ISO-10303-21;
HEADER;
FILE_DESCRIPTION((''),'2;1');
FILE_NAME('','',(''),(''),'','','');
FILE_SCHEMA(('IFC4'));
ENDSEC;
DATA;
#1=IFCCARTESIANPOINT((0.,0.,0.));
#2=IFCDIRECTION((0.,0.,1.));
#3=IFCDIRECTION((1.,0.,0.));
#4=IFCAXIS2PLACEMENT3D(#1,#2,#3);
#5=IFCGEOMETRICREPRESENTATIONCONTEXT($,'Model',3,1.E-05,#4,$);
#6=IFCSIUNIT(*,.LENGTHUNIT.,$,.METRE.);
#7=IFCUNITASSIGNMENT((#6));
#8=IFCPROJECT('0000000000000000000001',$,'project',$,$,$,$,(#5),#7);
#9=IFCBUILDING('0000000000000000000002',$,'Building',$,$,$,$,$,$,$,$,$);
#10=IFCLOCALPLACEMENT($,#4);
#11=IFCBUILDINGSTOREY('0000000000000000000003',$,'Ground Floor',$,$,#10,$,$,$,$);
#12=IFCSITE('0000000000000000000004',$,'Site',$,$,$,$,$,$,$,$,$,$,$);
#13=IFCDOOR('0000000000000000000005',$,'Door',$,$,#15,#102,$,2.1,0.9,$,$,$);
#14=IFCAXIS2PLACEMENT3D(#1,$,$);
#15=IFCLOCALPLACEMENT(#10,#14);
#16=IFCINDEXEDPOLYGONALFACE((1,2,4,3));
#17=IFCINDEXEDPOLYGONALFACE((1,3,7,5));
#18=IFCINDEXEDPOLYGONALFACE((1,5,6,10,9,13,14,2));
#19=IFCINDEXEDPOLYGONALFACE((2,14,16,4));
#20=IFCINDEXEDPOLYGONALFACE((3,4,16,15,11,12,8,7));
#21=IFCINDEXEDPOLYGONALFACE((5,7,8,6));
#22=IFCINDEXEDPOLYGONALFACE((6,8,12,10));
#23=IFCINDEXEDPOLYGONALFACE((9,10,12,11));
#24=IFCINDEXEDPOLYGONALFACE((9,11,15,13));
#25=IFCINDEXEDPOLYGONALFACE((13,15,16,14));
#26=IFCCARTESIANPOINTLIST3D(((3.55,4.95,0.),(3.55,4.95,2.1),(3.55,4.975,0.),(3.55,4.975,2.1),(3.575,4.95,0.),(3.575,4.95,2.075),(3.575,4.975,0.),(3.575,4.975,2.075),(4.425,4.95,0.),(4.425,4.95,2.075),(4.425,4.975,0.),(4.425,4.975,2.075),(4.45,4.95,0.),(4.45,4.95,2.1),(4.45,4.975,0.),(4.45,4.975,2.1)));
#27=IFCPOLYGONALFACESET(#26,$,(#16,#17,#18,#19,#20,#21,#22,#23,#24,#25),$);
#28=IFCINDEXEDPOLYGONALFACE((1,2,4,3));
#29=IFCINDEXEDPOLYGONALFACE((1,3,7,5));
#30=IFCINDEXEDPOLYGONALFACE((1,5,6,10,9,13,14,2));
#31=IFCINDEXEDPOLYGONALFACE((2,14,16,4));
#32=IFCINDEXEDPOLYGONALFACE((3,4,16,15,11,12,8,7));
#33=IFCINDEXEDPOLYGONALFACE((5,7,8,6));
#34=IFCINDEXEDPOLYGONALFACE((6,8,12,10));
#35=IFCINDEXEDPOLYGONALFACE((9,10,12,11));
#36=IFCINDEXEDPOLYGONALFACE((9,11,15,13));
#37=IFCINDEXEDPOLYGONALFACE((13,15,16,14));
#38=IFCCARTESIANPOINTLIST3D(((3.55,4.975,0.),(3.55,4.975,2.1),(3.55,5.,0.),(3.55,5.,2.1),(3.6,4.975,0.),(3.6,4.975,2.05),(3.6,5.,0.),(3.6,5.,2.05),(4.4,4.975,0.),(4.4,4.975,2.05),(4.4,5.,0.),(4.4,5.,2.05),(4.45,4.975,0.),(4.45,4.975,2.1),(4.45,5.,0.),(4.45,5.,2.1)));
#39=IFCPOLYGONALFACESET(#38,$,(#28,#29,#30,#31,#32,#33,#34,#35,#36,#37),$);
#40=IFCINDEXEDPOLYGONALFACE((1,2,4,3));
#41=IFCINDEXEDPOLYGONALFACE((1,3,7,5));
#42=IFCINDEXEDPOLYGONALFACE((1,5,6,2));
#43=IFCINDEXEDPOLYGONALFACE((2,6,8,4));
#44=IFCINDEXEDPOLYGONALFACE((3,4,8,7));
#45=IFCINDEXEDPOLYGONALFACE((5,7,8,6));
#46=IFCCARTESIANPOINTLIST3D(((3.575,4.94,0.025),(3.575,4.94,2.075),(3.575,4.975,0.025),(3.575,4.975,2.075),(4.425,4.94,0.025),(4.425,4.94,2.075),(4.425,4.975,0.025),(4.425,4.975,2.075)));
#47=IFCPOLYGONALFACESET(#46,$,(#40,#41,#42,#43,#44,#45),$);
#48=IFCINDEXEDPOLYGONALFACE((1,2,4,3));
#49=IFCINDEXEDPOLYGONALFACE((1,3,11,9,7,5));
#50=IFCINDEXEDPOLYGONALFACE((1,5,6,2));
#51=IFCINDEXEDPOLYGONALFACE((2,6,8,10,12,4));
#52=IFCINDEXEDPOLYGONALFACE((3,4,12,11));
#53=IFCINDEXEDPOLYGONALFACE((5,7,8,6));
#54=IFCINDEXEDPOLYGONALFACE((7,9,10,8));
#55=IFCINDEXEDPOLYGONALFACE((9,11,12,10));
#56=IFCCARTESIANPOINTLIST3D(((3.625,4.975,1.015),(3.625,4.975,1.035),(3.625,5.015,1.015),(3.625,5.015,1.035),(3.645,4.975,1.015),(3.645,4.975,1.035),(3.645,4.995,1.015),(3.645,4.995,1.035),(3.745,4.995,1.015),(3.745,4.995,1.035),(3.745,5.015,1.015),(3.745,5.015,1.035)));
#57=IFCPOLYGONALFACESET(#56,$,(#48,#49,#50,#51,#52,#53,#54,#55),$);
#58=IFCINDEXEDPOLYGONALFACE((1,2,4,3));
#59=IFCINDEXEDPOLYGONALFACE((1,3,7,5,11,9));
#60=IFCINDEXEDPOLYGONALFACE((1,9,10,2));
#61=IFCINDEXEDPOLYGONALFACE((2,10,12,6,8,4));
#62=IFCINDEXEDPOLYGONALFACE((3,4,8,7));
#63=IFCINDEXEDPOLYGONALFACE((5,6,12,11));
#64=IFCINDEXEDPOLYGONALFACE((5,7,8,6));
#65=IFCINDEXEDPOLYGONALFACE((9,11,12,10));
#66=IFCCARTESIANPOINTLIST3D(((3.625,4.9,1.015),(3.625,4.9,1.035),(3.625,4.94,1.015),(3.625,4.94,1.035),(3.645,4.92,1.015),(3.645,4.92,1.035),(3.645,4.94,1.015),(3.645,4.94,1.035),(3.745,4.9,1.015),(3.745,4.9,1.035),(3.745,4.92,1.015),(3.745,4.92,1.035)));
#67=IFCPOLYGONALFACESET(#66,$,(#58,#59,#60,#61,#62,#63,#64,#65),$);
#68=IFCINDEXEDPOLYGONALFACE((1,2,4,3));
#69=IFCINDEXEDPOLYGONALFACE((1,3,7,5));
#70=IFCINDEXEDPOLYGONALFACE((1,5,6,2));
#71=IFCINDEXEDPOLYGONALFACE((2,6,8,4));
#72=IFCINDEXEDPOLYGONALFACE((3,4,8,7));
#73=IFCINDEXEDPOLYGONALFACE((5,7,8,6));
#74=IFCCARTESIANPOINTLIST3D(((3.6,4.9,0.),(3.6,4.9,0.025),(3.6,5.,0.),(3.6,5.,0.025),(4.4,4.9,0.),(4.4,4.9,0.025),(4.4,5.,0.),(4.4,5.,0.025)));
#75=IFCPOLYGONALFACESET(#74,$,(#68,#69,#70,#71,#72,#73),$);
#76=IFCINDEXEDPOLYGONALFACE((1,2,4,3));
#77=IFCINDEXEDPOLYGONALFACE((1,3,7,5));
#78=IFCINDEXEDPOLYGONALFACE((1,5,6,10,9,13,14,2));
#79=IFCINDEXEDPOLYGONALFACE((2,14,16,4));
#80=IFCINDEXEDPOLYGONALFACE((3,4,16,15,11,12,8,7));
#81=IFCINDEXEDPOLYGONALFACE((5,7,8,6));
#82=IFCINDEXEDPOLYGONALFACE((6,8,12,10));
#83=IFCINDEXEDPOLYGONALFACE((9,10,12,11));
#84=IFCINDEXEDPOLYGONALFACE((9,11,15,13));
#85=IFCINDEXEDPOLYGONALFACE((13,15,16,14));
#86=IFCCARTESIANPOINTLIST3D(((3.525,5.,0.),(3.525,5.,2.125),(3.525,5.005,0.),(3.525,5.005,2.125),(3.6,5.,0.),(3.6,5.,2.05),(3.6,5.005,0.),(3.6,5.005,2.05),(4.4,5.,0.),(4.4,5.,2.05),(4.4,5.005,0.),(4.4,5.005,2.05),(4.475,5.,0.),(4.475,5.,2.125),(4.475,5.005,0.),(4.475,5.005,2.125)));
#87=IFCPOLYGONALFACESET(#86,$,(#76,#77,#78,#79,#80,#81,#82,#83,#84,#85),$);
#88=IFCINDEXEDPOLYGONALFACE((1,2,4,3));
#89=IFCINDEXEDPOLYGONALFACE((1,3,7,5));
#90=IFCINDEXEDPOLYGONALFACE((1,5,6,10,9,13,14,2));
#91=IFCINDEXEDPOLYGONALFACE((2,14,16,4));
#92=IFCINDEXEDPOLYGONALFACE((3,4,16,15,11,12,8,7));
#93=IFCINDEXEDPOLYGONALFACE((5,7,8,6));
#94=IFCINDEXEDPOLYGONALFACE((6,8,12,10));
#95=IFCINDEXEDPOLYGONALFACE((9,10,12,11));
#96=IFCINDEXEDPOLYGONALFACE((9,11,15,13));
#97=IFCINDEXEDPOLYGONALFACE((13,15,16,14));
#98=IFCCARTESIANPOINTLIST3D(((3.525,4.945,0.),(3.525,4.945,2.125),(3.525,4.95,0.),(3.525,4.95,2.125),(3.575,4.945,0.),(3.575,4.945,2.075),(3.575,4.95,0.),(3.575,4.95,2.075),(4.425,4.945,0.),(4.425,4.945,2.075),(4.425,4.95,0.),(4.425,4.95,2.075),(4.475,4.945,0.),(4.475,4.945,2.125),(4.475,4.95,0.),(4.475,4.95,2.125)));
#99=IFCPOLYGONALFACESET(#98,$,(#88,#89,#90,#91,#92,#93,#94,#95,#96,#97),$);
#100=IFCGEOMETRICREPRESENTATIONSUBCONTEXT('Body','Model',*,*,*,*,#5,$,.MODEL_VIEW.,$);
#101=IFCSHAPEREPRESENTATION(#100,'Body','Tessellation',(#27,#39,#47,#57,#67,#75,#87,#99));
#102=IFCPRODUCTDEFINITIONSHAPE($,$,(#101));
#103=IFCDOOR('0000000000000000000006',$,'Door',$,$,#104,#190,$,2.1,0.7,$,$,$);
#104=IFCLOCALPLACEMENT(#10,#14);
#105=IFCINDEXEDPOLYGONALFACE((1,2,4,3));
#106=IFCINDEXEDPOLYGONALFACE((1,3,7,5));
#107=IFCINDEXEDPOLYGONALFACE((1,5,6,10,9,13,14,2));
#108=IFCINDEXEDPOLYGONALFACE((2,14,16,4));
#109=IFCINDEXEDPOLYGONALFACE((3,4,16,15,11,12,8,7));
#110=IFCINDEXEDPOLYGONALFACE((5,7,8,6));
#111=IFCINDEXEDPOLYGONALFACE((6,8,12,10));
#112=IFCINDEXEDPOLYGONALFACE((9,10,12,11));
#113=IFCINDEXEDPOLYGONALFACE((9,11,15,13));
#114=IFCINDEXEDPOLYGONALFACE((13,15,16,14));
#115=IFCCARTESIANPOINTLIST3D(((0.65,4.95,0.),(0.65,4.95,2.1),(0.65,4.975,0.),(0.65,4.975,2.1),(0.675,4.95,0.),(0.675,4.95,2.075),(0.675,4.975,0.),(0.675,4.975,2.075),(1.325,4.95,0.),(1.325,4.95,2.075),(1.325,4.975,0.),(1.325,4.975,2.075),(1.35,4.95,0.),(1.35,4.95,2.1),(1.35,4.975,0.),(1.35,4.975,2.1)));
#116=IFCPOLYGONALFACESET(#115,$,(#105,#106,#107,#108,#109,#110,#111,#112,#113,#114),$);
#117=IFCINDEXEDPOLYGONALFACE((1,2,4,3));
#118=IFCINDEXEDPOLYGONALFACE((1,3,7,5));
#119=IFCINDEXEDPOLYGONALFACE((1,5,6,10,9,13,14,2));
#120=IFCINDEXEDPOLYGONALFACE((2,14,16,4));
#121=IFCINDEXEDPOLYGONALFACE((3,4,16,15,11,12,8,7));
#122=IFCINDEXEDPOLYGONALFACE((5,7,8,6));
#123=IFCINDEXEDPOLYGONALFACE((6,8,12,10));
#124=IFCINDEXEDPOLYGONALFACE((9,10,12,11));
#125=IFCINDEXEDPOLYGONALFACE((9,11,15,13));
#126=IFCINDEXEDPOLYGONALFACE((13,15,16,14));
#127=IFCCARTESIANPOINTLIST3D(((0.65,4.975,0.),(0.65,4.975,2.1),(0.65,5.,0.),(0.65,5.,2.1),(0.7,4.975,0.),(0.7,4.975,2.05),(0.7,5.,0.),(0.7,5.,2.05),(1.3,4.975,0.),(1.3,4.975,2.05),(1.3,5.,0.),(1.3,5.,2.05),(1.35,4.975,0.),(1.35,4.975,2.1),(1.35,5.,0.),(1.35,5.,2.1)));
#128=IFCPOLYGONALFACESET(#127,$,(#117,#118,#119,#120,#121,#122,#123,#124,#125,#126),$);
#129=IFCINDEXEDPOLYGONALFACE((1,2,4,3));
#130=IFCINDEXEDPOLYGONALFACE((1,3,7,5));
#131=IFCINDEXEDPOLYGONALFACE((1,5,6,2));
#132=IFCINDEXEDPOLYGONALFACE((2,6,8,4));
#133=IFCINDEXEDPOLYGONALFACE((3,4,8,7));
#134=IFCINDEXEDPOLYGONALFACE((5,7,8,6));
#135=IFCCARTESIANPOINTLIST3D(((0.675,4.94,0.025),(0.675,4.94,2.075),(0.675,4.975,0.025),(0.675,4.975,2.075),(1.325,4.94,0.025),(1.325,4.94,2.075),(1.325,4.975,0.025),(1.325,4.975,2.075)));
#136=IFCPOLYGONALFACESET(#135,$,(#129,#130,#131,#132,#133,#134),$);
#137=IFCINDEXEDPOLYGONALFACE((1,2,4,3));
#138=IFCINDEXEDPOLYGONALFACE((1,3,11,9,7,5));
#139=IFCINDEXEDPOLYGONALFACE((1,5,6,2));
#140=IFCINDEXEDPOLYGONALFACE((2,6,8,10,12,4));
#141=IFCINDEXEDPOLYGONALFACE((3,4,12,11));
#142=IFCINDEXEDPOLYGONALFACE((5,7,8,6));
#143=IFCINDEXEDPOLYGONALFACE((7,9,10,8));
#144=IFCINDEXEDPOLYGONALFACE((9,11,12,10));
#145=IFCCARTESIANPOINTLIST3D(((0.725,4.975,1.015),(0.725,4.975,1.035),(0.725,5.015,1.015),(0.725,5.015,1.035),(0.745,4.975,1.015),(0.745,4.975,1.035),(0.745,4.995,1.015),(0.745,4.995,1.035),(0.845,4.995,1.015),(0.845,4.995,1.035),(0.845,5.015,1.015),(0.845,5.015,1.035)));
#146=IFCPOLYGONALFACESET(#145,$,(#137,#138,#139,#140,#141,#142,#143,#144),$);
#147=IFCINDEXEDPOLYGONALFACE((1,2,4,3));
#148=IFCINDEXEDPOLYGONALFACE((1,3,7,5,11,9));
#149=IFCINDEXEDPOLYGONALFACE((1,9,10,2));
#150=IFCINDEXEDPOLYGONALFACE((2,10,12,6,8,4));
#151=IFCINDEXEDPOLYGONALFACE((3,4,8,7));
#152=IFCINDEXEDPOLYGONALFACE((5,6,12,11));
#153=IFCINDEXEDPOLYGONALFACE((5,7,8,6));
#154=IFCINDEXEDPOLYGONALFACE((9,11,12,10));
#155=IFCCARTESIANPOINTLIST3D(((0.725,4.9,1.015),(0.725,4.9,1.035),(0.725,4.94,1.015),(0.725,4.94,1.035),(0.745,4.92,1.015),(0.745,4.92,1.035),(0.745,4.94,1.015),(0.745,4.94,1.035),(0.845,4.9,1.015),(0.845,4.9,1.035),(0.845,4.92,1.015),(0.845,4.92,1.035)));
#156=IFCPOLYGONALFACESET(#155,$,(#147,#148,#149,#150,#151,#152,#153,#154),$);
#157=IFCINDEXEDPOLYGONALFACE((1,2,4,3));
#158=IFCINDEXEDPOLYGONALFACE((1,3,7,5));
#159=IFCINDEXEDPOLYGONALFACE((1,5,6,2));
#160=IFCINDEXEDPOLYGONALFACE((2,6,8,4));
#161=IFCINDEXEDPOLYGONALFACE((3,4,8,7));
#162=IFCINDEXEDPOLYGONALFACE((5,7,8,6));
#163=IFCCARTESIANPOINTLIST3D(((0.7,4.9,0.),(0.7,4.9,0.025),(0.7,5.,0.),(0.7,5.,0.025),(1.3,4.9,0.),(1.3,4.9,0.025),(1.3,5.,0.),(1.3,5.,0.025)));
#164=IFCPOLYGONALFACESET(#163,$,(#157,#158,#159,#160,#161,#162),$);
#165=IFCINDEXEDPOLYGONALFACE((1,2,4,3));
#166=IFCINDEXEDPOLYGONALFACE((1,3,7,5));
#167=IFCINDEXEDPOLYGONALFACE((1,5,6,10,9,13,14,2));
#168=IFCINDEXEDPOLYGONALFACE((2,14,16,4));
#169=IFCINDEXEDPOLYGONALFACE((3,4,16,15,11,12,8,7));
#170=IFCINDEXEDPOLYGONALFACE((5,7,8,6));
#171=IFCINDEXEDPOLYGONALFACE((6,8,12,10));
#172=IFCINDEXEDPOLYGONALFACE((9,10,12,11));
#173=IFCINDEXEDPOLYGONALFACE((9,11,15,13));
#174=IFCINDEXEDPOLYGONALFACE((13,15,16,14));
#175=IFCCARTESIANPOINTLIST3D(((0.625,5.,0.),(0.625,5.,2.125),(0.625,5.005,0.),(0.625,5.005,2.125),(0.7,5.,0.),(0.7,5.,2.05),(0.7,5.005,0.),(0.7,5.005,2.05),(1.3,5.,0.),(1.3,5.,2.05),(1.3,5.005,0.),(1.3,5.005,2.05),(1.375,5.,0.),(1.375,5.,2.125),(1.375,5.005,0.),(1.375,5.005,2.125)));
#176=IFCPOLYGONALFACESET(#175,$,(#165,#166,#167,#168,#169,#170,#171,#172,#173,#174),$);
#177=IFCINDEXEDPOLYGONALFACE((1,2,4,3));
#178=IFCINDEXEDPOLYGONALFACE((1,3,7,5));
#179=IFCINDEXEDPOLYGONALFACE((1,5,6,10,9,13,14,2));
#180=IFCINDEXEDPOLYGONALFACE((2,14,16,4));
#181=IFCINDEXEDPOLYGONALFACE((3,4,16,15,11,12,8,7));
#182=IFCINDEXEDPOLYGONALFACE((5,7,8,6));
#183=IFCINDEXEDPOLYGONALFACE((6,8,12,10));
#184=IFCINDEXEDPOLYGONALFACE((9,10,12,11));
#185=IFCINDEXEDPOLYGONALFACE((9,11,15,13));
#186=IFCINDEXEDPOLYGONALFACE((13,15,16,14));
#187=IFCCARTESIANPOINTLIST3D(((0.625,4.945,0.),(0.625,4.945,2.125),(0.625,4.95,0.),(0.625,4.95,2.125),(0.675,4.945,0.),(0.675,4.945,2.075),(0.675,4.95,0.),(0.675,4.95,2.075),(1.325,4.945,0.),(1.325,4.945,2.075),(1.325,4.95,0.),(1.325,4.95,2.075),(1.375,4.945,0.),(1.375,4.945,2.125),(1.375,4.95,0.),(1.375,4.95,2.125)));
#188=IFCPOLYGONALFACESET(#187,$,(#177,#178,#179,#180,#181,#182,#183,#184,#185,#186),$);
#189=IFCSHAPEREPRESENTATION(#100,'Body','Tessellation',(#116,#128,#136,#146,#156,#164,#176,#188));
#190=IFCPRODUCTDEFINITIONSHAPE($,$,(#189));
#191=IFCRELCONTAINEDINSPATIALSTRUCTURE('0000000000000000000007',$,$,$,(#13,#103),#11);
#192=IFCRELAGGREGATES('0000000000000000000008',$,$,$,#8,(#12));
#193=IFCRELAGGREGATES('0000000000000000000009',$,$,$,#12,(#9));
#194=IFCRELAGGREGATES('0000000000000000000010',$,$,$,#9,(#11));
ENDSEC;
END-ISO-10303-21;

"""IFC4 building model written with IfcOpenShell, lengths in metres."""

from ifc_helpers import new_model, si_unit, frame, origin_with_axes, place, context, subcontext, project, spatial, line, indexed_curve, outline, extrude, element, save


model = new_model("IFC4")

# Units and contexts
model_context = context("Model", 3, precision=1e-05, world=origin_with_axes())
body_context = subcontext(model_context, "Body", "Model", "MODEL_VIEW")
ifc_project = project(units=[si_unit("LENGTHUNIT", "METRE")], contexts=[model_context])

# Site, building, storey
site = spatial("IfcSite", under=ifc_project, Name="Site")
building = spatial("IfcBuilding", under=site, Name="Building")
storey_placement = place(None, origin_with_axes())
storey = spatial("IfcBuildingStorey", under=building, at=storey_placement, Name="Ground Floor")

# Doors
door_1_placement = place(storey_placement, frame((4.45, 5.0, 0.0), z_axis=(0.0, 0.0, 1.0), x_axis=(-1.0, 0.0, 0.0)))
element("IfcDoor", 1, at=door_1_placement, inside=storey, Name="Door", OverallHeight=2.1, OverallWidth=0.9, context=body_context, shape_type="SweptSolid", body=[
    extrude(outline(indexed_curve([(0.0, 0.0), (0.0, 2.1), (0.9, 2.1), (0.9, 0.0), (0.875, 0.0), (0.875, 2.075), (0.025, 2.075), (0.025, 0.0)], segments=[line(1, 2, 3, 4, 5, 6, 7, 8, 1)])), frame((0.0, 0.025, 0.0), z_axis=(0.0, -1.0, 0.0), x_axis=(1.0, 0.0, 0.0)), (0.0, 0.0, -1.0), 0.025),
    extrude(outline(indexed_curve([(0.0, 0.0), (0.0, 2.1), (0.9, 2.1), (0.9, 0.0), (0.85, 0.0), (0.85, 2.05), (0.05, 2.05), (0.05, 0.0)], segments=[line(1, 2, 3, 4, 5, 6, 7, 8, 1)])), frame((0.0, 0.0, 0.0), z_axis=(0.0, -1.0, 0.0), x_axis=(1.0, 0.0, 0.0)), (0.0, 0.0, -1.0), 0.025),
    extrude(outline(indexed_curve([(0.0, 0.0), (0.85, 0.0), (0.85, 0.035), (0.0, 0.035)], segments=[line(1, 2, 3, 4, 1)])), frame((0.025, 0.025, 0.025), z_axis=(0.0, 0.0, 1.0), x_axis=(1.0, 0.0, 0.0)), (0.0, 0.0, 1.0), 2.05),
    extrude(outline(indexed_curve([(0.0, 0.0), (0.0, -0.04), (-0.12, -0.04), (-0.12, -0.02), (-0.02, -0.02), (-0.02, 0.0)], segments=[line(1, 2, 3, 4, 5, 6, 1)])), frame((0.825, 0.025, 1.015), z_axis=(0.0, 0.0, 1.0), x_axis=(1.0, 0.0, 0.0)), (0.0, 0.0, 1.0), 0.02),
    extrude(outline(indexed_curve([(0.0, 0.0), (0.0, 0.04), (-0.12, 0.04), (-0.12, 0.02), (-0.02, 0.02), (-0.02, 0.0)], segments=[line(1, 2, 3, 4, 5, 6, 1)])), frame((0.825, 0.06, 1.015), z_axis=(0.0, 0.0, 1.0), x_axis=(1.0, 0.0, 0.0)), (0.0, 0.0, 1.0), 0.02),
    extrude(outline(indexed_curve([(0.0, 0.0), (0.8, 0.0), (0.8, 0.1), (0.0, 0.1)], segments=[line(1, 2, 3, 4, 1)])), frame((0.05, 0.0, 0.0), z_axis=(0.0, 0.0, 1.0), x_axis=(1.0, 0.0, 0.0)), (0.0, 0.0, 1.0), 0.025),
    extrude(outline(indexed_curve([(0.0, 0.0), (0.0, 2.125), (0.95, 2.125), (0.95, 0.0), (0.875, 0.0), (0.875, 2.05), (0.075, 2.05), (0.075, 0.0)], segments=[line(1, 2, 3, 4, 5, 6, 7, 8, 1)])), frame((-0.025, -0.005, 0.0), z_axis=(0.0, -1.0, 0.0), x_axis=(1.0, 0.0, 0.0)), (0.0, 0.0, -1.0), 0.005),
    extrude(outline(indexed_curve([(0.0, 0.0), (0.0, 2.125), (0.95, 2.125), (0.95, 0.0), (0.9, 0.0), (0.9, 2.075), (0.05, 2.075), (0.05, 0.0)], segments=[line(1, 2, 3, 4, 5, 6, 7, 8, 1)])), frame((-0.025, 0.05, 0.0), z_axis=(0.0, -1.0, 0.0), x_axis=(1.0, 0.0, 0.0)), (0.0, 0.0, -1.0), 0.005),
])
door_2_placement = place(storey_placement, frame((1.35, 5.0, 0.0), z_axis=(0.0, 0.0, 1.0), x_axis=(-1.0, 0.0, 0.0)))
element("IfcDoor", 2, at=door_2_placement, inside=storey, Name="Door", OverallHeight=2.1, OverallWidth=0.7, context=body_context, shape_type="SweptSolid", body=[
    extrude(outline(indexed_curve([(0.0, 0.0), (0.0, 2.1), (0.7, 2.1), (0.7, 0.0), (0.675, 0.0), (0.675, 2.075), (0.025, 2.075), (0.025, 0.0)], segments=[line(1, 2, 3, 4, 5, 6, 7, 8, 1)])), frame((0.0, 0.025, 0.0), z_axis=(0.0, -1.0, 0.0), x_axis=(1.0, 0.0, 0.0)), (0.0, 0.0, -1.0), 0.025),
    extrude(outline(indexed_curve([(0.0, 0.0), (0.0, 2.1), (0.7, 2.1), (0.7, 0.0), (0.65, 0.0), (0.65, 2.05), (0.05, 2.05), (0.05, 0.0)], segments=[line(1, 2, 3, 4, 5, 6, 7, 8, 1)])), frame((0.0, 0.0, 0.0), z_axis=(0.0, -1.0, 0.0), x_axis=(1.0, 0.0, 0.0)), (0.0, 0.0, -1.0), 0.025),
    extrude(outline(indexed_curve([(0.0, 0.0), (0.65, 0.0), (0.65, 0.035), (0.0, 0.035)], segments=[line(1, 2, 3, 4, 1)])), frame((0.025, 0.025, 0.025), z_axis=(0.0, 0.0, 1.0), x_axis=(1.0, 0.0, 0.0)), (0.0, 0.0, 1.0), 2.05),
    extrude(outline(indexed_curve([(0.0, 0.0), (0.0, -0.04), (-0.12, -0.04), (-0.12, -0.02), (-0.02, -0.02), (-0.02, 0.0)], segments=[line(1, 2, 3, 4, 5, 6, 1)])), frame((0.625, 0.025, 1.015), z_axis=(0.0, 0.0, 1.0), x_axis=(1.0, 0.0, 0.0)), (0.0, 0.0, 1.0), 0.02),
    extrude(outline(indexed_curve([(0.0, 0.0), (0.0, 0.04), (-0.12, 0.04), (-0.12, 0.02), (-0.02, 0.02), (-0.02, 0.0)], segments=[line(1, 2, 3, 4, 5, 6, 1)])), frame((0.625, 0.06, 1.015), z_axis=(0.0, 0.0, 1.0), x_axis=(1.0, 0.0, 0.0)), (0.0, 0.0, 1.0), 0.02),
    extrude(outline(indexed_curve([(0.0, 0.0), (0.6, 0.0), (0.6, 0.1), (0.0, 0.1)], segments=[line(1, 2, 3, 4, 1)])), frame((0.05, 0.0, 0.0), z_axis=(0.0, 0.0, 1.0), x_axis=(1.0, 0.0, 0.0)), (0.0, 0.0, 1.0), 0.025),
    extrude(outline(indexed_curve([(0.0, 0.0), (0.0, 2.125), (0.75, 2.125), (0.75, 0.0), (0.675, 0.0), (0.675, 2.05), (0.075, 2.05), (0.075, 0.0)], segments=[line(1, 2, 3, 4, 5, 6, 7, 8, 1)])), frame((-0.025, -0.005, 0.0), z_axis=(0.0, -1.0, 0.0), x_axis=(1.0, 0.0, 0.0)), (0.0, 0.0, -1.0), 0.005),
    extrude(outline(indexed_curve([(0.0, 0.0), (0.0, 2.125), (0.75, 2.125), (0.75, 0.0), (0.7, 0.0), (0.7, 2.075), (0.05, 2.075), (0.05, 0.0)], segments=[line(1, 2, 3, 4, 5, 6, 7, 8, 1)])), frame((-0.025, 0.05, 0.0), z_axis=(0.0, -1.0, 0.0), x_axis=(1.0, 0.0, 0.0)), (0.0, 0.0, -1.0), 0.005),
])

save(model, "model.ifc")
